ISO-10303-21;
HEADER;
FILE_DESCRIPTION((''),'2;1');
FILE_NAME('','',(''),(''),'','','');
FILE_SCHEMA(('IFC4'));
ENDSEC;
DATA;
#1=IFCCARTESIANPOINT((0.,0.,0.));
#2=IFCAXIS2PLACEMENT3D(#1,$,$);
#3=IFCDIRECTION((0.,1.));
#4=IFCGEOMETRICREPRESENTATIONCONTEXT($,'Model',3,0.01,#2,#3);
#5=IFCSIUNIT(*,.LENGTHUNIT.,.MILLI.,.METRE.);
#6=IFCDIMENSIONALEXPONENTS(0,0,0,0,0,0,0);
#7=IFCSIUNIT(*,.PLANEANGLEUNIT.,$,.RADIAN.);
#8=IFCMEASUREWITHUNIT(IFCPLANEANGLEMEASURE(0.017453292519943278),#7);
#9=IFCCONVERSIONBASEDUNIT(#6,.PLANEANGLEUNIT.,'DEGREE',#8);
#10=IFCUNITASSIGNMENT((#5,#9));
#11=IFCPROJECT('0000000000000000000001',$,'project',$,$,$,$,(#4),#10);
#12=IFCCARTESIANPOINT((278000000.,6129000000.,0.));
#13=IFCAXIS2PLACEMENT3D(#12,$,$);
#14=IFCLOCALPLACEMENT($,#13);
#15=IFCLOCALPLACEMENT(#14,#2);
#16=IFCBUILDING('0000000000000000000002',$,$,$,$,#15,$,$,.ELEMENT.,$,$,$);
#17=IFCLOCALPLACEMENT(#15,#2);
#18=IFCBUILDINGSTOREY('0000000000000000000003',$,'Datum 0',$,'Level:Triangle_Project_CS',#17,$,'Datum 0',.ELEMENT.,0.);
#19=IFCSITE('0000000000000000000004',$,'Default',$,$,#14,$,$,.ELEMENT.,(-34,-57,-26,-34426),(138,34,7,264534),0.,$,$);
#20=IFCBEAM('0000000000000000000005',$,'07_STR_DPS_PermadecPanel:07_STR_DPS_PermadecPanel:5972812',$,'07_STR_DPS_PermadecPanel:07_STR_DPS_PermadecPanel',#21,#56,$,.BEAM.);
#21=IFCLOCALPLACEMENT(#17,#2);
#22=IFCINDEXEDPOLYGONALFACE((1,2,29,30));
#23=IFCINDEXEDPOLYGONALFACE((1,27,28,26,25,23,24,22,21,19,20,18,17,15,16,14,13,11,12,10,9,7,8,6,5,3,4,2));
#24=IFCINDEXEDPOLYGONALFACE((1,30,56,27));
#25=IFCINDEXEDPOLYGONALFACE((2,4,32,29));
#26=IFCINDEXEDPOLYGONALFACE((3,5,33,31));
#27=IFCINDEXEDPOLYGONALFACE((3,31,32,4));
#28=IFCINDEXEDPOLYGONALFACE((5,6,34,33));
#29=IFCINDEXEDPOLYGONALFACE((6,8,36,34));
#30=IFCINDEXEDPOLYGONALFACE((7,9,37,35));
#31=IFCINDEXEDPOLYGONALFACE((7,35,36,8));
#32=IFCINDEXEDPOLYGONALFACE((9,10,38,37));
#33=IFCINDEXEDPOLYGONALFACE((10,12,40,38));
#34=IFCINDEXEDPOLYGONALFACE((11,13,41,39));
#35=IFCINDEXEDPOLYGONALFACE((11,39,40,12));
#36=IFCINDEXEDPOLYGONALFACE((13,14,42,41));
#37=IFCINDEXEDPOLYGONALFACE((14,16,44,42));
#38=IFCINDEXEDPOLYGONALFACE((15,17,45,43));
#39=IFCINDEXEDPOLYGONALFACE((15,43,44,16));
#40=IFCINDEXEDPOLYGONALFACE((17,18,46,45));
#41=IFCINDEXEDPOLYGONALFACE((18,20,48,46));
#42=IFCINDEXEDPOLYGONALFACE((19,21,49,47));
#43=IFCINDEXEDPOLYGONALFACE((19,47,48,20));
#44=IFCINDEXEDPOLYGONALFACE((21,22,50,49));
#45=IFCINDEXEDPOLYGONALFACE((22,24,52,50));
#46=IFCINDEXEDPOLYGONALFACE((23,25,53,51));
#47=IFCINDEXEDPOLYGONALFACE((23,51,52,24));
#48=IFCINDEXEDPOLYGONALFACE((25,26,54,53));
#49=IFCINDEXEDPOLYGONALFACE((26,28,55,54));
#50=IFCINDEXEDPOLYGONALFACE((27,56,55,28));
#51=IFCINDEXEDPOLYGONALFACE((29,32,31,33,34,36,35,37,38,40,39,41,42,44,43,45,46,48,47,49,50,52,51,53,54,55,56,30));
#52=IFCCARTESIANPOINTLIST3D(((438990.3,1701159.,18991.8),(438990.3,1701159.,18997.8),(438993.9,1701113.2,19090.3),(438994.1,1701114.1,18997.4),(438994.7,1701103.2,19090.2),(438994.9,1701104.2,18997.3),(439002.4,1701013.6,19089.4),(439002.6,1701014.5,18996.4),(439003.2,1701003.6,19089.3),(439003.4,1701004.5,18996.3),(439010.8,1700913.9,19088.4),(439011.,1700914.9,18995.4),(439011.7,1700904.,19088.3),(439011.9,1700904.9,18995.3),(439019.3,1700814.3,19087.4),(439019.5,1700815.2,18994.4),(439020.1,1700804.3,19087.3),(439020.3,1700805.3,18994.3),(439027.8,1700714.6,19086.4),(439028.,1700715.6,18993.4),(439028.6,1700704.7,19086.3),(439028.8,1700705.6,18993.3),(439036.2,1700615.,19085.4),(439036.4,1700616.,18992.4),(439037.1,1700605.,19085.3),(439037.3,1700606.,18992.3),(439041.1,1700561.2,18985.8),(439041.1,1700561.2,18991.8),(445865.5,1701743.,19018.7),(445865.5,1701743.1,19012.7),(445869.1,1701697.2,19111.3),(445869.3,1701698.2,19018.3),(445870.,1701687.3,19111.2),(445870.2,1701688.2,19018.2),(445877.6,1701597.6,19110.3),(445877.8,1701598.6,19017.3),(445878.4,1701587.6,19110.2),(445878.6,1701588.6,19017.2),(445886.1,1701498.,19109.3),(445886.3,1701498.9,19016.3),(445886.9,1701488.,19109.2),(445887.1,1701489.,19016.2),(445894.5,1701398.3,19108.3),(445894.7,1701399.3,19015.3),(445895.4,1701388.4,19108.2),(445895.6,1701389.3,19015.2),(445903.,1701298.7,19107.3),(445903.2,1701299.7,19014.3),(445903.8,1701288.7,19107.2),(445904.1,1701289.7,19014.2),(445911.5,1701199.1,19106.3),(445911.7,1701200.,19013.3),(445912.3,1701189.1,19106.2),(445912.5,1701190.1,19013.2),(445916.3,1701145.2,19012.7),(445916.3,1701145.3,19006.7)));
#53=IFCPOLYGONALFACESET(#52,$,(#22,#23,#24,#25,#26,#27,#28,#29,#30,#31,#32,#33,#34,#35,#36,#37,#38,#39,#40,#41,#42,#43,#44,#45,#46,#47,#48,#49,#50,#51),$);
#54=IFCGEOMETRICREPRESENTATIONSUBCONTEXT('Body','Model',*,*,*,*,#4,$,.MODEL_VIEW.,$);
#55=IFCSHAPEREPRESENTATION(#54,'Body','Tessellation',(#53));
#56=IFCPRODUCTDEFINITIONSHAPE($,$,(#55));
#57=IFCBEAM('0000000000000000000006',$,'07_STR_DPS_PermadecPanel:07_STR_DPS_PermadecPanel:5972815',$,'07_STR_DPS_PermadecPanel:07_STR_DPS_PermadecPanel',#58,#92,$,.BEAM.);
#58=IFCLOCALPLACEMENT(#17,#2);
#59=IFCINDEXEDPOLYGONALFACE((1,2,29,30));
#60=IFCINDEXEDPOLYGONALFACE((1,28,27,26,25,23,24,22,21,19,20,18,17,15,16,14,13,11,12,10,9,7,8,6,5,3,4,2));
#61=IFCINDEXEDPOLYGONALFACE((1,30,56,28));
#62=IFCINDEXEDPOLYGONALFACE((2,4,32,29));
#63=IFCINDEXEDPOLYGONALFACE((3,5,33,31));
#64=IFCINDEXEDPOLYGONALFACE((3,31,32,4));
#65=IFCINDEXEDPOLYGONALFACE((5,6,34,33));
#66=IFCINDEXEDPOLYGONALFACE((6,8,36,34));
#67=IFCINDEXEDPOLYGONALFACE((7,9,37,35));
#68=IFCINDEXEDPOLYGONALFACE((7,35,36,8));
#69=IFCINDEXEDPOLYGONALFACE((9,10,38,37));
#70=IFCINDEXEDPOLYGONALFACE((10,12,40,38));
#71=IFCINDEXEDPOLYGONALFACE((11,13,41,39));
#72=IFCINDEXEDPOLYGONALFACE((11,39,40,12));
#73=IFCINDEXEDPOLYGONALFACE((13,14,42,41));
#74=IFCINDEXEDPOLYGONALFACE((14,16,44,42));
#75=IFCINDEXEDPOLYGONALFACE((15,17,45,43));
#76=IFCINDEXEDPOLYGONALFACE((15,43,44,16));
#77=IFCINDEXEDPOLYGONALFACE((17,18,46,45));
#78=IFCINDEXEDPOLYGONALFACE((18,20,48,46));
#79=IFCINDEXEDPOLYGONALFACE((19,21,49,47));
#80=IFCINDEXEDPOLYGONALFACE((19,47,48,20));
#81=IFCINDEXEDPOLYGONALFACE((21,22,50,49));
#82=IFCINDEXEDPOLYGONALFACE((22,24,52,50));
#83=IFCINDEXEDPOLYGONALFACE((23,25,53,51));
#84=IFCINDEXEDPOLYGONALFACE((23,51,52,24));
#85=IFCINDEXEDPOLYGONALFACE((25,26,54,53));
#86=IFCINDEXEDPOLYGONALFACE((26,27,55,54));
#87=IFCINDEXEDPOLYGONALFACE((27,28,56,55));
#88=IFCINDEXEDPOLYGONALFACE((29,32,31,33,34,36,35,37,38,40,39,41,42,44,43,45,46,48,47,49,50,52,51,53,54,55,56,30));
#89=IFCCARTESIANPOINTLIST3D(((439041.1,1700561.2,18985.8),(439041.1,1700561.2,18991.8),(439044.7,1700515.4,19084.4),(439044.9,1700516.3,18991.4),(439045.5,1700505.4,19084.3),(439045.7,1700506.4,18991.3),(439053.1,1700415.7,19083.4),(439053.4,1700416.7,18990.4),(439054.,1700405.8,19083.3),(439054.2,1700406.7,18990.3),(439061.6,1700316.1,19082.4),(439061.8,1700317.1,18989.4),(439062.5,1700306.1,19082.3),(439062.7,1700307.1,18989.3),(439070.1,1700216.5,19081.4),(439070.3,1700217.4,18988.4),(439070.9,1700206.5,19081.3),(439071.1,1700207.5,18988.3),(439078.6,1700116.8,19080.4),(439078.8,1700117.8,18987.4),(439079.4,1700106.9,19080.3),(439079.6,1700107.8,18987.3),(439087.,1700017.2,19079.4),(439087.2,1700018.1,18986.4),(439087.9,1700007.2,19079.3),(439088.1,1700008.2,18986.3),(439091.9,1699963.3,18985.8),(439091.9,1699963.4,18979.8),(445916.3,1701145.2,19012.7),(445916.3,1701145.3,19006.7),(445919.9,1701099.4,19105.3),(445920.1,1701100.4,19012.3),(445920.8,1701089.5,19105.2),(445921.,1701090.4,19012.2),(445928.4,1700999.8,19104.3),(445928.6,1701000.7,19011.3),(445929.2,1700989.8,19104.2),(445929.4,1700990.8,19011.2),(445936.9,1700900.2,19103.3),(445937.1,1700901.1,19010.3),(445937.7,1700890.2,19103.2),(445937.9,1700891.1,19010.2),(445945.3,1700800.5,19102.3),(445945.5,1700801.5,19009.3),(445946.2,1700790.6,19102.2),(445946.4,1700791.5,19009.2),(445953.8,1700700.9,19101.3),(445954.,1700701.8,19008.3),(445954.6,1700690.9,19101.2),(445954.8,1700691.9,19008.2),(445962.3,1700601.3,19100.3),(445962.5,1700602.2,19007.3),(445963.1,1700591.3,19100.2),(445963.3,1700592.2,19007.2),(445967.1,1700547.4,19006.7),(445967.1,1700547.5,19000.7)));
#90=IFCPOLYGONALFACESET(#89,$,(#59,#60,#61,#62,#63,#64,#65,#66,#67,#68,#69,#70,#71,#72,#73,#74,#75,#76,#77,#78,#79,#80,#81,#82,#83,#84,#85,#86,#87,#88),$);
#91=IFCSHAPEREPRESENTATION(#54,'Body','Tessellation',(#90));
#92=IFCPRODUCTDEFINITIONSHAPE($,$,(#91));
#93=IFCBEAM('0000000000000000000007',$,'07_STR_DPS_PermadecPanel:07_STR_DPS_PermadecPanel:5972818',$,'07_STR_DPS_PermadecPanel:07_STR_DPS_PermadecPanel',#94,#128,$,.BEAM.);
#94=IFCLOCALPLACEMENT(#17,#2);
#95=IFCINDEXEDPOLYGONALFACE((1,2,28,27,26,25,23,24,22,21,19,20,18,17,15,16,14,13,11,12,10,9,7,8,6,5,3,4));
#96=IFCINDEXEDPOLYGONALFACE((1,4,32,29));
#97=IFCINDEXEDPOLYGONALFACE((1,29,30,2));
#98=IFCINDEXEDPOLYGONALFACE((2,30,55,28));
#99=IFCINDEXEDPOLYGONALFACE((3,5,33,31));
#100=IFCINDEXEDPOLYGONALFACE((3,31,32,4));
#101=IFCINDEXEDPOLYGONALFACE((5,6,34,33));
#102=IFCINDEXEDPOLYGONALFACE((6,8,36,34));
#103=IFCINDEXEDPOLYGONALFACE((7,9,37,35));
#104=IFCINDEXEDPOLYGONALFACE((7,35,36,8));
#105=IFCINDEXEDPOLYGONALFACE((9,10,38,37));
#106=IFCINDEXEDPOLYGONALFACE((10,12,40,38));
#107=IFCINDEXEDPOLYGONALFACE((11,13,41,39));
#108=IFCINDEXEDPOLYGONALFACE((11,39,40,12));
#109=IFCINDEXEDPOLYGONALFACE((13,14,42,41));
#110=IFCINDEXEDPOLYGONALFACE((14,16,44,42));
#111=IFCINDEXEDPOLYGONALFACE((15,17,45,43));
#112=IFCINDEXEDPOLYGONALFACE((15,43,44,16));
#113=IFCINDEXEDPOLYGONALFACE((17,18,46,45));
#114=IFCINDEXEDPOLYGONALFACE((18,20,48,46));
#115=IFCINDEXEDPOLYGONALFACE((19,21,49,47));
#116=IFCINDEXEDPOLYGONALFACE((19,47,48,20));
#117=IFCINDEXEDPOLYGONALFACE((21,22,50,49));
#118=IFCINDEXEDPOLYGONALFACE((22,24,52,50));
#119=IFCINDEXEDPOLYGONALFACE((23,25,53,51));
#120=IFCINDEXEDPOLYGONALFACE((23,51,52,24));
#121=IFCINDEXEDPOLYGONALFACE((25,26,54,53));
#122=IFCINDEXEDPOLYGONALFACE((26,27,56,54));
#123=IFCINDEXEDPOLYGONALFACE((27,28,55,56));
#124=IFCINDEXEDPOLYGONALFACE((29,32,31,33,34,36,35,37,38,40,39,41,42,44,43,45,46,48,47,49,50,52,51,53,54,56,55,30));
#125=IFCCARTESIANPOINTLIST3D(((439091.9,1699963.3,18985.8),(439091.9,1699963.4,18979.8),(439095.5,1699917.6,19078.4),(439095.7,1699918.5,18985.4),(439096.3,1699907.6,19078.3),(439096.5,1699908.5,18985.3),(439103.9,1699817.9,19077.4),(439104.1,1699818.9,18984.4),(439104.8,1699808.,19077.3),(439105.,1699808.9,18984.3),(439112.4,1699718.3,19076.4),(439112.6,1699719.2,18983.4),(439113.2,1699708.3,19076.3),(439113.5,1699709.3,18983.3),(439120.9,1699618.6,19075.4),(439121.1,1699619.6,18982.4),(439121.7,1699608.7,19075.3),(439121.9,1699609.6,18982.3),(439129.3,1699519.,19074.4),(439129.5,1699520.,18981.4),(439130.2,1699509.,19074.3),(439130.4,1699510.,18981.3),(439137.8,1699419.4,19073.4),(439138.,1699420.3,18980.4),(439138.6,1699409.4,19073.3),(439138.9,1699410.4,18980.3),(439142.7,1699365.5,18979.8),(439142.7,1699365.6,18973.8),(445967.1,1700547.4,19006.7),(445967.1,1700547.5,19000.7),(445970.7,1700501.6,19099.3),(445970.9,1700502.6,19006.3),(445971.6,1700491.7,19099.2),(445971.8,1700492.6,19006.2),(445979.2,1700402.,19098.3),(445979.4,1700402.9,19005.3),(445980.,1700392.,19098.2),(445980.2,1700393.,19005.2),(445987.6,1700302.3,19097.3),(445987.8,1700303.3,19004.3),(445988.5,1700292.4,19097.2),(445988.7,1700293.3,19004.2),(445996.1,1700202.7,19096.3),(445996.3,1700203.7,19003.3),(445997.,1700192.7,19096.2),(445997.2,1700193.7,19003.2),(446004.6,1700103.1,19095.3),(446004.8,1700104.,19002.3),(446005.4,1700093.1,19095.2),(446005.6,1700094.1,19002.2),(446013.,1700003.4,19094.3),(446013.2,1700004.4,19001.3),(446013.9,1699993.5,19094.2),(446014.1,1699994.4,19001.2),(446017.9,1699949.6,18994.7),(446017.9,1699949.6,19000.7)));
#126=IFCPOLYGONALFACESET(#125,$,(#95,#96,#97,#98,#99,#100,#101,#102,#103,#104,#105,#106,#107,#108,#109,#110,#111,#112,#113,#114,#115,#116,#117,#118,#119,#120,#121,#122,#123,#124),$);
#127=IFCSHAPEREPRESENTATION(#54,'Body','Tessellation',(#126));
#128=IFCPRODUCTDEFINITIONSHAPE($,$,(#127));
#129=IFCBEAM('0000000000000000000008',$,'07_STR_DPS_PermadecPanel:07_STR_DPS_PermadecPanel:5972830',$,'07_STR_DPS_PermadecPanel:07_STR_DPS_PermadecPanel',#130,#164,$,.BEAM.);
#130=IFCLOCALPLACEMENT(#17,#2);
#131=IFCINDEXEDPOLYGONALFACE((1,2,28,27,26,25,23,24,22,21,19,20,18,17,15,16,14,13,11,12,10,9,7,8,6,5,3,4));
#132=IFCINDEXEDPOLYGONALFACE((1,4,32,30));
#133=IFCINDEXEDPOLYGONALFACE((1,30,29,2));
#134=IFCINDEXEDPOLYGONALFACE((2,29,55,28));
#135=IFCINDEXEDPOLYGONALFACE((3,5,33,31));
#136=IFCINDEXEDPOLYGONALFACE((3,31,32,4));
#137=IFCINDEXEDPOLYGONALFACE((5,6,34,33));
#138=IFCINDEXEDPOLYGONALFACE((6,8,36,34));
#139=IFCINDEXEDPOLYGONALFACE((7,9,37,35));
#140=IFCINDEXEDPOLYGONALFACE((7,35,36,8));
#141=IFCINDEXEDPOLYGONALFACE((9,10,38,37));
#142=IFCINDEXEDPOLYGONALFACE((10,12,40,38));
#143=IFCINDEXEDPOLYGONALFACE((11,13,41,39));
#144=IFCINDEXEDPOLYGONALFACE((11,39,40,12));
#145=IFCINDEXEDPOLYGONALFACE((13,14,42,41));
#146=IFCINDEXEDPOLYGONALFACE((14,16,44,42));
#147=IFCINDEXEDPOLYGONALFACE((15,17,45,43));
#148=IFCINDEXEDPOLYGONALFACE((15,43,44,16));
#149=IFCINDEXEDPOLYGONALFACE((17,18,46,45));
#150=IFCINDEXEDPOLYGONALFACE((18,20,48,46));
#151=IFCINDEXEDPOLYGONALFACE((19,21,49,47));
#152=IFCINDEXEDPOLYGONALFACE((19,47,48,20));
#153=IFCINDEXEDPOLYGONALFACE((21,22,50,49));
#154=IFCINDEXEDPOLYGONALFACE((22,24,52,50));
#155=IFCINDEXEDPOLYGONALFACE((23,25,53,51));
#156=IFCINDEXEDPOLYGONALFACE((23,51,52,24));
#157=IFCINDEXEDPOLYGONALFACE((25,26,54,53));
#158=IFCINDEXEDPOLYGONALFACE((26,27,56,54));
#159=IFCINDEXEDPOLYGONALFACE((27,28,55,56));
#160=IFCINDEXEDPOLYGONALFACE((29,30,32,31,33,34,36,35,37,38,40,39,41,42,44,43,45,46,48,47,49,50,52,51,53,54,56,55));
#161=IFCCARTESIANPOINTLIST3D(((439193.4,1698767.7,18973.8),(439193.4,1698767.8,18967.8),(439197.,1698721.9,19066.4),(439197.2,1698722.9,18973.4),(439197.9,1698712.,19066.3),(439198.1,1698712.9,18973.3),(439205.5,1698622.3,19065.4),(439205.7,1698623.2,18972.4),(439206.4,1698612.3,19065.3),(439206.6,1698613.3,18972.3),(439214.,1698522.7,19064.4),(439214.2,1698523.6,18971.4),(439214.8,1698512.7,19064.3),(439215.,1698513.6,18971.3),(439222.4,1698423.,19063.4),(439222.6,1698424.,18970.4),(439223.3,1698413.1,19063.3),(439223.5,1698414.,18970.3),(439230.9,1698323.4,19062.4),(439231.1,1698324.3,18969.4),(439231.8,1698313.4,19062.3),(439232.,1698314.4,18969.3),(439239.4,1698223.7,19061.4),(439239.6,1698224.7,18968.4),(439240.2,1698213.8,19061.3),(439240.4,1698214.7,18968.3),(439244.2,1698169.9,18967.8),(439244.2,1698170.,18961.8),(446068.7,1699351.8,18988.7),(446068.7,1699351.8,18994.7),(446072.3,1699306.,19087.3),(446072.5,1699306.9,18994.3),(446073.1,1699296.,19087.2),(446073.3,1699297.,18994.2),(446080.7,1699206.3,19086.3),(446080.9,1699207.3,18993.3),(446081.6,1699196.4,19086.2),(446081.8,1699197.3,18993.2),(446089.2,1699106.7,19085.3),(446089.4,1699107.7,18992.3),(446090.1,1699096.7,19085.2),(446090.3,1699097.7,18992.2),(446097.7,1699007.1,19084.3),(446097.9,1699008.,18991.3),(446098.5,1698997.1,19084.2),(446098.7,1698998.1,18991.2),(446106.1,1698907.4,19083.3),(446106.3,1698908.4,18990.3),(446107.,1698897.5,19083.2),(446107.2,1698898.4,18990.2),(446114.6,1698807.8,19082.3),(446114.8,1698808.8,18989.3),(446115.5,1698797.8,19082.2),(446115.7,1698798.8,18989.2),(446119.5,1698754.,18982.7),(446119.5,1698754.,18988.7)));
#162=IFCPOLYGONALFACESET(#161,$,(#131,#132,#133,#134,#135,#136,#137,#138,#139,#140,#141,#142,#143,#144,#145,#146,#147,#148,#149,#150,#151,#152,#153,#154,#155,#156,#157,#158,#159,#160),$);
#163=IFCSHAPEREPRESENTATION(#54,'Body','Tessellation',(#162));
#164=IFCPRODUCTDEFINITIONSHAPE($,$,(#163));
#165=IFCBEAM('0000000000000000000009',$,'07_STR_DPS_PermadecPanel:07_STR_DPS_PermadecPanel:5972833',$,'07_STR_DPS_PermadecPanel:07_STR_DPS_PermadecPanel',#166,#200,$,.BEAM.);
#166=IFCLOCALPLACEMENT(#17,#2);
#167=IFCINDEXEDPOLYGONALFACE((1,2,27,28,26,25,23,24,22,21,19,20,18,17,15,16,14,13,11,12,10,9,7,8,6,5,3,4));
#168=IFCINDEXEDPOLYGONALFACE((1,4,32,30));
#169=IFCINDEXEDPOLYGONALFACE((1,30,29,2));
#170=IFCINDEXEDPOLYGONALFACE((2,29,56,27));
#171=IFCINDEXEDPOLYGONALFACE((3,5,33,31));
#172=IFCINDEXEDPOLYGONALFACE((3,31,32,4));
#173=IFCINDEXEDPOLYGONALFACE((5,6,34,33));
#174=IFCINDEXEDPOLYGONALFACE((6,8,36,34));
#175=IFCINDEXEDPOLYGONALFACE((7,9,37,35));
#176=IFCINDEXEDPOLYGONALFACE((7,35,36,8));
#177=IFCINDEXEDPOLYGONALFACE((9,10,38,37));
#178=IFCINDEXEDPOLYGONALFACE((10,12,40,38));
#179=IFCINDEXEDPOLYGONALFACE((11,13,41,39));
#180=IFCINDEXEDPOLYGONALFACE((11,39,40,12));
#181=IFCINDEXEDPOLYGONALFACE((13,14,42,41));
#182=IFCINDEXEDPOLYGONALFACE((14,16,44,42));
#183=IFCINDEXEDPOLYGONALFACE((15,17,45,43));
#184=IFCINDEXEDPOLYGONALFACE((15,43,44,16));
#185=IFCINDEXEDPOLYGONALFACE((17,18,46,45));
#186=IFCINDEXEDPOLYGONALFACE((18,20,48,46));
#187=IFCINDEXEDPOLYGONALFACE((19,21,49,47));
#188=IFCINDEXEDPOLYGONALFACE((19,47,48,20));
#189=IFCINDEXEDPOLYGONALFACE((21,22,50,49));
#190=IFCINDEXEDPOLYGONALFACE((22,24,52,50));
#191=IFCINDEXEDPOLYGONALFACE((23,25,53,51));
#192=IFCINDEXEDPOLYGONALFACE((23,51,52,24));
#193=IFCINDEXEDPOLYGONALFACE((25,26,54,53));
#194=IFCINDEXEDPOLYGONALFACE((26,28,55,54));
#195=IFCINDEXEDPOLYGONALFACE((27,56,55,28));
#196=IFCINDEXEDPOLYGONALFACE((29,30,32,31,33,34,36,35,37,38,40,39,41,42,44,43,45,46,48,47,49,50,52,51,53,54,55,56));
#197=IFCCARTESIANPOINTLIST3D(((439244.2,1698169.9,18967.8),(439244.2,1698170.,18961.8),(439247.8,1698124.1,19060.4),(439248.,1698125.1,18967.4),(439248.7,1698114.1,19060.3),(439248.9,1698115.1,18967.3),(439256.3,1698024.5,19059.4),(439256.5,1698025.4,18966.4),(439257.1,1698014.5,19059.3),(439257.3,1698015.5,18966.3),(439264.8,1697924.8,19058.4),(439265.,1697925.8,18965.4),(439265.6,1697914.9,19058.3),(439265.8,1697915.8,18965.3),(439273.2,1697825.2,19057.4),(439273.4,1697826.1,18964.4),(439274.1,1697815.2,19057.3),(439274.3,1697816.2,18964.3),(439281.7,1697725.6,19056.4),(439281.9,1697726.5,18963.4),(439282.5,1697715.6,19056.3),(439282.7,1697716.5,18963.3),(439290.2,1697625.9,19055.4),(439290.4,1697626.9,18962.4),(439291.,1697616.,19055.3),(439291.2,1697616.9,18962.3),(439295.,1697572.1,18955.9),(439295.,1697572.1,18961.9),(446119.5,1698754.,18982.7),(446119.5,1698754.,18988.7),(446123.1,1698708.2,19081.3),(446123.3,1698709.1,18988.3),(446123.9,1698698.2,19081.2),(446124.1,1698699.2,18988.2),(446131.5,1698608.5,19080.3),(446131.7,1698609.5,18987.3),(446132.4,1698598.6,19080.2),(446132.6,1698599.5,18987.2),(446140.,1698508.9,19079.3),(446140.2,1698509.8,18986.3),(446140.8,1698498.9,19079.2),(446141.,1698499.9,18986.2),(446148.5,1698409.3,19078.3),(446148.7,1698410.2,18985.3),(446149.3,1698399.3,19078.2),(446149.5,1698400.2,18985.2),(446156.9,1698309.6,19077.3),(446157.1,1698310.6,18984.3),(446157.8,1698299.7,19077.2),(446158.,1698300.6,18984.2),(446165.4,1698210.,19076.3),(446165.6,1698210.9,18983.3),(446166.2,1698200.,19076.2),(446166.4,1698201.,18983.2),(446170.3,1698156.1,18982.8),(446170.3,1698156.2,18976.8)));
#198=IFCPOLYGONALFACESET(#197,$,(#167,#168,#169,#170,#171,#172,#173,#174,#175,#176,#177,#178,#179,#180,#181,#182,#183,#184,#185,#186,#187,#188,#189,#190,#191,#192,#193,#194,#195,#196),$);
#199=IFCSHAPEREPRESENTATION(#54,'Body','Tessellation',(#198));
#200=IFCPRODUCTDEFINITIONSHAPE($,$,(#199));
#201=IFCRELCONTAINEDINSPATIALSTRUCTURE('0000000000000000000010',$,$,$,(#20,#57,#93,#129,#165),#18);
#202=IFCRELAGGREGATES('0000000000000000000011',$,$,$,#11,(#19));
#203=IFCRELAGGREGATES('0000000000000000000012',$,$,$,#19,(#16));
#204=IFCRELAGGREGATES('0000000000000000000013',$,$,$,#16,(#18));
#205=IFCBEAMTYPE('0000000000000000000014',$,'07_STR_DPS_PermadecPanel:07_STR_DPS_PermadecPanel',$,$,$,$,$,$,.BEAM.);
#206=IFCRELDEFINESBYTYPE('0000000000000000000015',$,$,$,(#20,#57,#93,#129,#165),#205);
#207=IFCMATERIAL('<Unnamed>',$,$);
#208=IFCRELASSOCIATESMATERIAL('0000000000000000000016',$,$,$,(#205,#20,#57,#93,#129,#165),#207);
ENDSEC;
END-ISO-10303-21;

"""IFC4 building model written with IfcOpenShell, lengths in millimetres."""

from ifc_helpers import new_model, entity, si_unit, converted_unit, direction, frame, origin, place, context, subcontext, project, spatial, indexed_curve, outline, extrude, source, transform, mapped, material, type_object, type_shapes, element, save


model = new_model("IFC4")

# Units and contexts
model_context = context("Model", 3, precision=0.01, world=origin(), true_north=direction((0.0, 1.0)))
body_context = subcontext(model_context, "Body", "Model", "MODEL_VIEW")
ifc_project = project(units=[si_unit("LENGTHUNIT", "METRE", prefix="MILLI"), converted_unit("PLANEANGLEUNIT", "DEGREE", entity("IfcPlaneAngleMeasure", 0.017453292519943278), si_unit("PLANEANGLEUNIT", "RADIAN"), dimensions=[0, 0, 0, 0, 0, 0, 0])], contexts=[model_context])

# Site, building, storey
site_placement = place(None, frame((278000000.0, 6129000000.0, 0.0)))
site = spatial("IfcSite", under=ifc_project, at=site_placement, Name="Default", CompositionType="ELEMENT", RefLatitude=(-34, -57, -26, -34426), RefLongitude=(138, 34, 7, 264534), RefElevation=0.0)
building_placement = place(site_placement, origin())
building = spatial("IfcBuilding", under=site, at=building_placement, CompositionType="ELEMENT")
storey_placement = place(building_placement, frame((0.0, 0.0, 0.0)))
storey = spatial("IfcBuildingStorey", under=building, at=storey_placement, Name="Datum 0", ObjectType="Level:Triangle_Project_CS", LongName="Datum 0", CompositionType="ELEMENT", Elevation=0.0)

# Beams
ifc_material_1 = material(Name="<Unnamed>")
beam_type_1 = type_object("IfcBeamType", Name="07_STR_DPS_PermadecPanel:07_STR_DPS_PermadecPanel", PredefinedType="BEAM", material=ifc_material_1)
shared_shape_1 = source(origin(), body_context, "Body", "SweptSolid", [
    extrude(outline(indexed_curve([(-300.0, -45.4), (300.0, -45.4), (300.0, -39.4), (255.0, -39.4), (255.0, 53.6), (245.0, 53.6), (245.0, -39.4), (155.0, -39.4), (155.0, 53.6), (145.0, 53.6), (145.0, -39.4), (55.0, -39.4), (55.0, 53.6), (45.0, 53.6), (45.0, -39.4), (-45.0, -39.4), (-45.0, 53.6), (-55.0, 53.6), (-55.0, -39.4), (-145.0, -39.4), (-145.0, 53.6), (-155.0, 53.6), (-155.0, -39.4), (-245.0, -39.4), (-245.0, 53.6), (-255.0, 53.6), (-255.0, -39.4), (-300.0, -39.4), (-300.0, -45.4)], self_intersect=False)), frame((-3450.0, 0.0, 45.4), z_axis=(1.0, 0.0, 0.0), x_axis=(0.0, 1.0, 0.0)), (0.0, 0.0, 1.0), 6900.0),
])
type_shapes(beam_type_1, [shared_shape_1])
for number, where, z_axis, x_axis, name in (
    (1, (442453.3, 1701152.2, 18999.3), (-0.002173, -0.010208, 0.999946), (-0.996406, -0.084646, -0.00303), "07_STR_DPS_PermadecPanel:07_STR_DPS_PermadecPanel:5972812"),
    (2, (442504.1, 1700554.3, 18993.3), (-0.002173, -0.010208, 0.999946), (-0.996406, -0.084646, -0.00303), "07_STR_DPS_PermadecPanel:07_STR_DPS_PermadecPanel:5972815"),
    (3, (442554.9, 1699956.5, 18987.3), (-0.002173, -0.010208, 0.999946), (-0.996406, -0.084646, -0.00303), "07_STR_DPS_PermadecPanel:07_STR_DPS_PermadecPanel:5972818"),
    (4, (442656.5, 1698760.9, 18975.3), (-0.002173, -0.010208, 0.999946), (-0.996406, -0.084646, -0.00303), "07_STR_DPS_PermadecPanel:07_STR_DPS_PermadecPanel:5972830"),
    (5, (442707.2, 1698163.1, 18969.3), (-0.002173, -0.010208, 0.999946), (-0.996406, -0.084646, -0.00303), "07_STR_DPS_PermadecPanel:07_STR_DPS_PermadecPanel:5972833"),
):
    element("IfcBeam", number, at=place(storey_placement, frame(where, z_axis=z_axis, x_axis=x_axis)), inside=storey, type_object=beam_type_1, material=ifc_material_1, Name=name, ObjectType="07_STR_DPS_PermadecPanel:07_STR_DPS_PermadecPanel", PredefinedType="BEAM", context=body_context, shape_type="MappedRepresentation", body=[
        mapped(shared_shape_1, transform((0.0, 0.0, 0.0), scale=1.0)),
    ])

save(model, "model.ifc")
